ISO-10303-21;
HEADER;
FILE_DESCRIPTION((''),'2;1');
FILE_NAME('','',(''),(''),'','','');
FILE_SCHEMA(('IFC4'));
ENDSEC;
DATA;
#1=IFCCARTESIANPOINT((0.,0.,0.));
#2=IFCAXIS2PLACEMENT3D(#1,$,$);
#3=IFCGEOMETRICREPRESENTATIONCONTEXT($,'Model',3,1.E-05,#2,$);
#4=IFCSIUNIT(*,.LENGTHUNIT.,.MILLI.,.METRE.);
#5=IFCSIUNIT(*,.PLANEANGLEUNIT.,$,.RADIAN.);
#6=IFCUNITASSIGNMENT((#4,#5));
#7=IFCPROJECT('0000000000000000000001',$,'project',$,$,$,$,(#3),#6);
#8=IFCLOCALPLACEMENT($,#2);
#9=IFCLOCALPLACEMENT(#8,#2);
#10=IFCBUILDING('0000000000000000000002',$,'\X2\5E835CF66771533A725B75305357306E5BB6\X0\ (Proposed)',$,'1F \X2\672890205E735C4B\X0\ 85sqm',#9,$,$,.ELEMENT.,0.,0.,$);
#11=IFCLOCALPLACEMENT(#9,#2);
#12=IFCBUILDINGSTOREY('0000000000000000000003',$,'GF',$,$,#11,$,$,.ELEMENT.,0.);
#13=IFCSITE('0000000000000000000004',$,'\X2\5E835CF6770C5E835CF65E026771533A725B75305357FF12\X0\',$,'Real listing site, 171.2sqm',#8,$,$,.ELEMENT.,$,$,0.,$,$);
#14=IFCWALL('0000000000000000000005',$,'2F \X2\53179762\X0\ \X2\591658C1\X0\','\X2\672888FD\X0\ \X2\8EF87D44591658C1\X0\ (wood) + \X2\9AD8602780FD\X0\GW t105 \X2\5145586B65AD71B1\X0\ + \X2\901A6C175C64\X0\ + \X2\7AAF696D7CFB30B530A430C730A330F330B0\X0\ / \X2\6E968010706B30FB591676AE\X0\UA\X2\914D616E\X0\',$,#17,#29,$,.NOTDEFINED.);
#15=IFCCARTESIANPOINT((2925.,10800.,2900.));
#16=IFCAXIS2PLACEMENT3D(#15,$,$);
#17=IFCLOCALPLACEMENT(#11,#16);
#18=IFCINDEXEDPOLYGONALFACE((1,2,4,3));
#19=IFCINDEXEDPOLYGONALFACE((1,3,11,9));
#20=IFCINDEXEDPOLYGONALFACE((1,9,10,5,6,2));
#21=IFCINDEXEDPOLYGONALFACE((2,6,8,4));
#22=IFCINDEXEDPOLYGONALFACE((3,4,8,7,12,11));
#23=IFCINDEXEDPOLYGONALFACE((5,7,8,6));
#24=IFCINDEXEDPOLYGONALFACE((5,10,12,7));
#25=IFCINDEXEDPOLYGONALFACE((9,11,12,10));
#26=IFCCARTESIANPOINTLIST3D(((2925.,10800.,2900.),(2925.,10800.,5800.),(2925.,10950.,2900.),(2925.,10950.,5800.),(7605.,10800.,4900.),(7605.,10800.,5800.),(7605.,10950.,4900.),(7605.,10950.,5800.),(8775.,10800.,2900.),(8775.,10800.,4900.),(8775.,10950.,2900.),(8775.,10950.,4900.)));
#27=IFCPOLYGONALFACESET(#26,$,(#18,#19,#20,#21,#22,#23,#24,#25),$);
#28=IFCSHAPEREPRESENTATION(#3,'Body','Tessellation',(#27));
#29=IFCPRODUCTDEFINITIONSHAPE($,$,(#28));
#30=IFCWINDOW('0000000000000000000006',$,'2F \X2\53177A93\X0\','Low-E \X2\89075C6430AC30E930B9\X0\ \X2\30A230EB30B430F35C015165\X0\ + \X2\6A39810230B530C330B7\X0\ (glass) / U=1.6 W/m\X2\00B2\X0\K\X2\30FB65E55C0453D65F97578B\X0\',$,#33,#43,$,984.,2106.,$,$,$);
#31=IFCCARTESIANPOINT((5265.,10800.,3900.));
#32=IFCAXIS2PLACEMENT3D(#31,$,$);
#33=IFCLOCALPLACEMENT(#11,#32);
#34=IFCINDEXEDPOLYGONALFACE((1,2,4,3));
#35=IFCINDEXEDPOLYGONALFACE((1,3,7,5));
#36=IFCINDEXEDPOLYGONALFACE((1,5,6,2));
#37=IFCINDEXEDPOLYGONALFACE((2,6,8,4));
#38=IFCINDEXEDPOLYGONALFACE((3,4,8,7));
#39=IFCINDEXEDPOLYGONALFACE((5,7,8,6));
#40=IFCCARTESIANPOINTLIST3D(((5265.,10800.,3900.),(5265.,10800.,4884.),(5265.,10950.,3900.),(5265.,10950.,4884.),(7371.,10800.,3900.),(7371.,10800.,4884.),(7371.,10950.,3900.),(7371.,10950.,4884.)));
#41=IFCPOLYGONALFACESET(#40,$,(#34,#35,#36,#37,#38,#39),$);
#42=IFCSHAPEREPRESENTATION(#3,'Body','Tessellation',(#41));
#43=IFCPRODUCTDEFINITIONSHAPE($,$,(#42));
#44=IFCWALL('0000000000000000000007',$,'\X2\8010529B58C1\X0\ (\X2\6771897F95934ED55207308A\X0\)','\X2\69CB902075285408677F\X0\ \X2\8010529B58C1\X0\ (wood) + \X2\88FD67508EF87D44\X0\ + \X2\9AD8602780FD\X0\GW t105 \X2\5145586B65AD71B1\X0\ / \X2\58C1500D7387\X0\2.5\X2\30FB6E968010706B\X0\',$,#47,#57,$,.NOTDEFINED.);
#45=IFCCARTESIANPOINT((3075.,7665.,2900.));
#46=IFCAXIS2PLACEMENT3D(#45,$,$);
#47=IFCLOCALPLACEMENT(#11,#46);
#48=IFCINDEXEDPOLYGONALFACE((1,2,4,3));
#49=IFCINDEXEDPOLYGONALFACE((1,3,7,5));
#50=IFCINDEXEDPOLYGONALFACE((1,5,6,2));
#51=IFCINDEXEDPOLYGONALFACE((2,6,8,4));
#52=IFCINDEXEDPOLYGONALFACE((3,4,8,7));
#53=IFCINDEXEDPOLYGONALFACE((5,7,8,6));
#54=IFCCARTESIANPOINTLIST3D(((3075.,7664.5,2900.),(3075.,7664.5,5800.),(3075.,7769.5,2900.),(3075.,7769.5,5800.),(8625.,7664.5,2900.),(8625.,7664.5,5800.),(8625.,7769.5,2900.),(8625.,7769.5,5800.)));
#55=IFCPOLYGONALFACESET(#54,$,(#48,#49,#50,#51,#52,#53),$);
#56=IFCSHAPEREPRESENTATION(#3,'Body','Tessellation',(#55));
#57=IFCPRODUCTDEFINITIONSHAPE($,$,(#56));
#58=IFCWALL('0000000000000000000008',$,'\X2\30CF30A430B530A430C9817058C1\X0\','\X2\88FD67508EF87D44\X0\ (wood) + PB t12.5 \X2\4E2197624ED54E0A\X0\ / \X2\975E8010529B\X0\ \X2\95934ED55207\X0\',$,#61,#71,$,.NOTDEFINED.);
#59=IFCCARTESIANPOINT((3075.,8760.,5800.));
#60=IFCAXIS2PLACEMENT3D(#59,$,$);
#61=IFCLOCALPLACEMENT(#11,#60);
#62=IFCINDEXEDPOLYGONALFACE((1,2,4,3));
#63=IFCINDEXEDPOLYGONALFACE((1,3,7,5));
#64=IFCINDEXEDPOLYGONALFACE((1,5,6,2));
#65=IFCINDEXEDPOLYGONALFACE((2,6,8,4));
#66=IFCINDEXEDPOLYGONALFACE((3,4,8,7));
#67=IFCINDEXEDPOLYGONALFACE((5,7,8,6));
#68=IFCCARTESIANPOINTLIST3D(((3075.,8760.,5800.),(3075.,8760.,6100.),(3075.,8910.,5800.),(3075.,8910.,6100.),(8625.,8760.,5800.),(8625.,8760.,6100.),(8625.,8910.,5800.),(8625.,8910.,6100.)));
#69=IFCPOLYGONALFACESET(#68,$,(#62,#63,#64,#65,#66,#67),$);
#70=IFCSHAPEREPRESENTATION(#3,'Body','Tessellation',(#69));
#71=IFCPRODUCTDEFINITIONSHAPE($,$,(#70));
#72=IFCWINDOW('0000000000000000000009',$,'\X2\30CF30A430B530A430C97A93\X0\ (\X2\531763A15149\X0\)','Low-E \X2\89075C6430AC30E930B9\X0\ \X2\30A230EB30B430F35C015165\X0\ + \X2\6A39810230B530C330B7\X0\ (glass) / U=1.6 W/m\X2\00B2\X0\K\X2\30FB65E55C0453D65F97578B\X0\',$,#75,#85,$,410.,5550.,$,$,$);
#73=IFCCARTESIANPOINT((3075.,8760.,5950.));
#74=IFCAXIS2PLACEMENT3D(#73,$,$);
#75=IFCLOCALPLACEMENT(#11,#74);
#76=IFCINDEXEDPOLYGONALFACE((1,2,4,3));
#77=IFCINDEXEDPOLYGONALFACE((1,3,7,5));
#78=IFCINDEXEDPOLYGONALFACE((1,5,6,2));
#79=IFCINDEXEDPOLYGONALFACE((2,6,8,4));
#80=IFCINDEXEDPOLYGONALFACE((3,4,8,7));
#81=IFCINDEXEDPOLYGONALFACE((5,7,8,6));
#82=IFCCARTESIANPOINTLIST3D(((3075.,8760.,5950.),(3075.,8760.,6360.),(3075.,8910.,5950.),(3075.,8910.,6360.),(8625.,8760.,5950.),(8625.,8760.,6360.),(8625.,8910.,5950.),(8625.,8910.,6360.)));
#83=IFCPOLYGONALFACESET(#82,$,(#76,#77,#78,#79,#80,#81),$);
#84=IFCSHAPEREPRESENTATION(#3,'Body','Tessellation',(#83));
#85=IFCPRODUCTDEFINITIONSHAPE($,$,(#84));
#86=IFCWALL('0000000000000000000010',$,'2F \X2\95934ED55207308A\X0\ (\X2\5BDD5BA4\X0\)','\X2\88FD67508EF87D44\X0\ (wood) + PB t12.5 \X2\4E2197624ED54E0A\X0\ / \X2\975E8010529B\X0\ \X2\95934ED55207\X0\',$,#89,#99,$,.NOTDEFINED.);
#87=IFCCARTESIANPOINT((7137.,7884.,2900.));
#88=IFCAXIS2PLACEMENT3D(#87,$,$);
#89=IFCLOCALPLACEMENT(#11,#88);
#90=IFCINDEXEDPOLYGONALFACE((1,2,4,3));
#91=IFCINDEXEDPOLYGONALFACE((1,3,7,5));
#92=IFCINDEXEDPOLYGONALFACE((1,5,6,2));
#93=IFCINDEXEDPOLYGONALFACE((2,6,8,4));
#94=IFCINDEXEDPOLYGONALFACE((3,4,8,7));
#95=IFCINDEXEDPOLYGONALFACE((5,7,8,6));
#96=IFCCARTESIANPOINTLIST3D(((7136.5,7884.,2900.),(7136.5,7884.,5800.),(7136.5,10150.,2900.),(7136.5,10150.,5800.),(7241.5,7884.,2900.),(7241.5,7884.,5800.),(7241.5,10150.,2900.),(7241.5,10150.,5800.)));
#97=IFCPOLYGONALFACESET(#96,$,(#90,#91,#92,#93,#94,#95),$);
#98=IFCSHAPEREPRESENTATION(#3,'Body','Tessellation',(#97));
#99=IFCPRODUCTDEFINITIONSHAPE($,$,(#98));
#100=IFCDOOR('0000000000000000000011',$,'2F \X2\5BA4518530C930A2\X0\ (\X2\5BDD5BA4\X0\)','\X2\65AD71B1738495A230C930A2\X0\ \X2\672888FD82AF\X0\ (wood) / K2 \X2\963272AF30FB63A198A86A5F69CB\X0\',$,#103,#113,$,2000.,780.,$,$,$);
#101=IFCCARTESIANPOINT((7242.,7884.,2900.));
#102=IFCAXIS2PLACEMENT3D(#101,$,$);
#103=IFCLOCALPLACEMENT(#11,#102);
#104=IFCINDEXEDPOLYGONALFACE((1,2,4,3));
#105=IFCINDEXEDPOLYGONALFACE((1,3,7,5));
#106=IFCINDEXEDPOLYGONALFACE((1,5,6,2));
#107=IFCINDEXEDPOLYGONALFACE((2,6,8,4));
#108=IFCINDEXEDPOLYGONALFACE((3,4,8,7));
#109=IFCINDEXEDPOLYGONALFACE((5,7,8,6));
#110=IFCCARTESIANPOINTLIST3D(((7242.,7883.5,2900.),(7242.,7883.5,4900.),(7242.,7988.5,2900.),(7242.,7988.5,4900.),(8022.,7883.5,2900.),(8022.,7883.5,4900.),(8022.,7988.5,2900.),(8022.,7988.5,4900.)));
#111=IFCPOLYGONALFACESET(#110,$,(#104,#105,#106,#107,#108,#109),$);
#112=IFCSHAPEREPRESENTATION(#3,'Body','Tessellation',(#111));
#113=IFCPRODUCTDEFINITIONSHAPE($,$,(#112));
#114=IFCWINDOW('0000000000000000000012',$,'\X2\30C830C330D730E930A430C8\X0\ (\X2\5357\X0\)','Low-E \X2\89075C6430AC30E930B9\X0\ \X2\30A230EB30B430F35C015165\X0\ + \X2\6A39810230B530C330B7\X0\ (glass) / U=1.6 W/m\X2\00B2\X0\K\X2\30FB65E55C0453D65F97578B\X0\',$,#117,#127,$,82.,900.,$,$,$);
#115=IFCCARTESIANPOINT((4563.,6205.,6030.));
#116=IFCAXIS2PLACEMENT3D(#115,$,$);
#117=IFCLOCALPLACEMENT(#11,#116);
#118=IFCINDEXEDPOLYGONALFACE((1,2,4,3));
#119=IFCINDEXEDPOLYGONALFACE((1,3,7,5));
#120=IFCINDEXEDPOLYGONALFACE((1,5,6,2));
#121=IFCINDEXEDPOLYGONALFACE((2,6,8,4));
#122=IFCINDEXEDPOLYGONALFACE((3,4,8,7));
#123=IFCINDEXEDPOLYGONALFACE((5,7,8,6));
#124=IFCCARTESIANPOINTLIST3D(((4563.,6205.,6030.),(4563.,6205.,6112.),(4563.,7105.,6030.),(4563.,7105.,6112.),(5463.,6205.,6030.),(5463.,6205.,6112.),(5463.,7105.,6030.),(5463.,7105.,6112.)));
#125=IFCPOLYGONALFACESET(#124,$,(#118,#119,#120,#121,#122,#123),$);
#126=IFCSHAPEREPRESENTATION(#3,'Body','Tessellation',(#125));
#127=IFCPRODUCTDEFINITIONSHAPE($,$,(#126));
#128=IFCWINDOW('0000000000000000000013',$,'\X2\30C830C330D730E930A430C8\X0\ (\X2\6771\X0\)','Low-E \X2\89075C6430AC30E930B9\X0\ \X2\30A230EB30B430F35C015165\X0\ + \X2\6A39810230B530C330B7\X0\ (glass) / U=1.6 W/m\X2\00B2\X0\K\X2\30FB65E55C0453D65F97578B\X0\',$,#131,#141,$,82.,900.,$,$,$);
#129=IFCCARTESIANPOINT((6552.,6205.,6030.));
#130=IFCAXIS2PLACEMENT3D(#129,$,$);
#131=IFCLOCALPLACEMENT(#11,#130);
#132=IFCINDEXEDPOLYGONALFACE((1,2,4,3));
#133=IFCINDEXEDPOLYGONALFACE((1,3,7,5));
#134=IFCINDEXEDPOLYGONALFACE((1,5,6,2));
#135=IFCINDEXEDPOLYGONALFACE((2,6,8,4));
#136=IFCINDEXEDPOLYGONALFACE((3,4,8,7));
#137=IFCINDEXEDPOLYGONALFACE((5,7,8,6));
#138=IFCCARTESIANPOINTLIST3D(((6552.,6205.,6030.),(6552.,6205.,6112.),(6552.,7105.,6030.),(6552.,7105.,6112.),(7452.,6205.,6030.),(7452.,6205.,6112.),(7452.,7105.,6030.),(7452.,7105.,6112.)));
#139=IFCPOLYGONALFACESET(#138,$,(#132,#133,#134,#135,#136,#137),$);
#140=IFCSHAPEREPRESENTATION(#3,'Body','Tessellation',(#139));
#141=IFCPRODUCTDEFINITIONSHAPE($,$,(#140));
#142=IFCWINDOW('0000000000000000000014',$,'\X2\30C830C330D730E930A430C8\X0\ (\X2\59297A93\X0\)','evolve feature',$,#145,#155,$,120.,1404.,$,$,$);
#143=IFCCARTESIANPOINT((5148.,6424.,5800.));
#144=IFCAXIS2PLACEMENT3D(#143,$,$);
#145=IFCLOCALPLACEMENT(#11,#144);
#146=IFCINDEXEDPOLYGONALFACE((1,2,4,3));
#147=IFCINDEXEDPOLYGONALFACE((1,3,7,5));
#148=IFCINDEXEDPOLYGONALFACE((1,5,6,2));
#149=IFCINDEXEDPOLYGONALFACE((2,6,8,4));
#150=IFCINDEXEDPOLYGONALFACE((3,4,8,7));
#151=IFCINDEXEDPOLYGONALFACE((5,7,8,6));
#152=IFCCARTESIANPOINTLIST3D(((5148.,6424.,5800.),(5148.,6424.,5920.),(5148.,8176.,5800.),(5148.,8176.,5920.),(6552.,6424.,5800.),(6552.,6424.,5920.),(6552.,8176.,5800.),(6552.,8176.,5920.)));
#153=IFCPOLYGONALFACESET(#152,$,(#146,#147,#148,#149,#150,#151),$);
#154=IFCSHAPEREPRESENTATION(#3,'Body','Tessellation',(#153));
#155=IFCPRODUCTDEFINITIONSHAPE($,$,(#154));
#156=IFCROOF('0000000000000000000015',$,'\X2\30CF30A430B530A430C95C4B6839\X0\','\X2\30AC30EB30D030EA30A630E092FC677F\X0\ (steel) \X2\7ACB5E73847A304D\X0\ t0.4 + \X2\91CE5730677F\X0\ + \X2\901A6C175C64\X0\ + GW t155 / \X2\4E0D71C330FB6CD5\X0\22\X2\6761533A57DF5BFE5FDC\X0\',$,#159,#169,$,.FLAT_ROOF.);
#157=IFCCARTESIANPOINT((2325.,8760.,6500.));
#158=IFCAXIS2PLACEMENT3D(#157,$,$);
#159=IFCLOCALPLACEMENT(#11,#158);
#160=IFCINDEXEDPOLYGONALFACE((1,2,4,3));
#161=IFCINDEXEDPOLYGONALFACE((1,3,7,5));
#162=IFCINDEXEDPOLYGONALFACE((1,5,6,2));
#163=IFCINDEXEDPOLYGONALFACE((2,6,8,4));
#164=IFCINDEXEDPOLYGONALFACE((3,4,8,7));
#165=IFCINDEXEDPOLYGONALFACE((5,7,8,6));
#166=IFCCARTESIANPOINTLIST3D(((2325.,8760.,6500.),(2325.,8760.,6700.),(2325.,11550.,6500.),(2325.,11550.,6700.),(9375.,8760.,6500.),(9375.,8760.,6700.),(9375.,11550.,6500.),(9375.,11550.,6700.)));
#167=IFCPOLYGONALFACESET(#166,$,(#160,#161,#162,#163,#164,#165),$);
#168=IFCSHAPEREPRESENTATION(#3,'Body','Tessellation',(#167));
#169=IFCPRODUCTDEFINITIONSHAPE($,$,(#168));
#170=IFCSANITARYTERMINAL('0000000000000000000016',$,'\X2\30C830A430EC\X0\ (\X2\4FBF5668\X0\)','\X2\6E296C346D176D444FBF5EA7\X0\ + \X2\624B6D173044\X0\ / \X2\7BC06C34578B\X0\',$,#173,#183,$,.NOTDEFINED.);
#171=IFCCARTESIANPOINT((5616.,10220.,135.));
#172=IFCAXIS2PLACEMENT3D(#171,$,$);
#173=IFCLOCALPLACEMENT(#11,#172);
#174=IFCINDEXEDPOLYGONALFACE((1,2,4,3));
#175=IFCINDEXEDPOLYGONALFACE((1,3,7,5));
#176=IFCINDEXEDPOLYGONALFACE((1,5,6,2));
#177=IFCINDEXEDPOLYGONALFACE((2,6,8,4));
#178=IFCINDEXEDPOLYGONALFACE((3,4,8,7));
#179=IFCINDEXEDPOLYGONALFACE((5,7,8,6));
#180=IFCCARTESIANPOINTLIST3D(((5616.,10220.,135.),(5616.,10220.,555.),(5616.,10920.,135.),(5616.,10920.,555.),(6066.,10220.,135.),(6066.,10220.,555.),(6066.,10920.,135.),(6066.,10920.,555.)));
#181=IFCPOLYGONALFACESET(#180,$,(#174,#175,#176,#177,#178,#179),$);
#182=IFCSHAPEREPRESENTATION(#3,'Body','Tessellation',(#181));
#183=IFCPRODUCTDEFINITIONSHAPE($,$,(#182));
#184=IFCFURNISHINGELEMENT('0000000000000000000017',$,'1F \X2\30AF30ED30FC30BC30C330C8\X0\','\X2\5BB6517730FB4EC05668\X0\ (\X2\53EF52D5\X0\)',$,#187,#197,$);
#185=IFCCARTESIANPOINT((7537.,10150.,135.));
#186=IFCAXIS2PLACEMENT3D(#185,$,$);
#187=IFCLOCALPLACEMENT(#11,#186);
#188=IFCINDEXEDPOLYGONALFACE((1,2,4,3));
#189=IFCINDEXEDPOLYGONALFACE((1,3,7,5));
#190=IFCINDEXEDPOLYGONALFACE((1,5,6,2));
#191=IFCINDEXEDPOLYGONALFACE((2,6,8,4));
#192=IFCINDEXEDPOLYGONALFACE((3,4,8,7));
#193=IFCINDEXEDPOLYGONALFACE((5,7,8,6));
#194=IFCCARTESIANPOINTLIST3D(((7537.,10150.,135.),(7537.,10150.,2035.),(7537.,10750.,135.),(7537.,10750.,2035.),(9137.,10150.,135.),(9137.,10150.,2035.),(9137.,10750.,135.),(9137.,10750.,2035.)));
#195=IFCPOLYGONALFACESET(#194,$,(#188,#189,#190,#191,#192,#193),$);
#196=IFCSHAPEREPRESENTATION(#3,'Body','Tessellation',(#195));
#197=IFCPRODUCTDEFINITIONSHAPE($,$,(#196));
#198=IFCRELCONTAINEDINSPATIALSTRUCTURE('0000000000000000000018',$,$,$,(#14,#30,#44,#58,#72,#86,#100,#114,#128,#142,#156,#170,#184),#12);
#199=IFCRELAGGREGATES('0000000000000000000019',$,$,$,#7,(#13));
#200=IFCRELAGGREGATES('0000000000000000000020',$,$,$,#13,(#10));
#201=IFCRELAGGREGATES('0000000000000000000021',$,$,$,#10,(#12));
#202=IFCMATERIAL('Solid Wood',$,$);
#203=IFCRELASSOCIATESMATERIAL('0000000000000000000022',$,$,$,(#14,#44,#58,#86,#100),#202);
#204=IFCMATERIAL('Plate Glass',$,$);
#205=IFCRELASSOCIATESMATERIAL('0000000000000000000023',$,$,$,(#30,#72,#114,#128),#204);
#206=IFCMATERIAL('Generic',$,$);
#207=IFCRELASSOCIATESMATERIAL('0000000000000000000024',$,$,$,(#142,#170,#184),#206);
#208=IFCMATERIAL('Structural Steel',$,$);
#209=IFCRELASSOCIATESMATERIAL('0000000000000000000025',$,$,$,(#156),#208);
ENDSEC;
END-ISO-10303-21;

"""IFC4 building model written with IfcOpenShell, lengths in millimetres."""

from ifc_helpers import new_model, si_unit, frame, frame_2d, origin, place, context, project, spatial, rectangle, extrude, material, element, fill, save


model = new_model("IFC4")

# Units and contexts
model_context = context("Model", 3, precision=1e-05, world=origin())
ifc_project = project(units=[si_unit("LENGTHUNIT", "METRE", prefix="MILLI"), si_unit("PLANEANGLEUNIT", "RADIAN")], contexts=[model_context])

# Site, building, storey
site_placement = place(None, origin())
site = spatial("IfcSite", under=ifc_project, at=site_placement, Name="広島県広島市東区牛田南２", ObjectType="Real listing site, 171.2sqm", CompositionType="ELEMENT", RefElevation=0.0)
building_placement = place(site_placement, origin())
building = spatial("IfcBuilding", under=site, at=building_placement, Name="広島東区牛田南の家 (Proposed)", ObjectType="1F 木造平屋 85sqm", CompositionType="ELEMENT", ElevationOfRefHeight=0.0, ElevationOfTerrain=0.0)
storey_placement = place(building_placement, origin())
storey = spatial("IfcBuildingStorey", under=building, at=storey_placement, Name="GF", CompositionType="ELEMENT", Elevation=0.0)

# Wall, opening, window
ifc_material_1 = material(Name="Solid Wood")
wall_1_placement = place(storey_placement, frame((2925.0, 10800.0, 2900.0)))
wall_1 = element("IfcWall", 1, at=wall_1_placement, inside=storey, material=ifc_material_1, Name="2F 北面 外壁", Description="木製 軸組外壁 (wood) + 高性能GW t105 充填断熱 + 通気層 + 窯業系サイディング / 準耐火・外皮UA配慮", PredefinedType="NOTDEFINED", context=model_context, shape_type="SweptSolid", body=[
    extrude(rectangle(XDim=5850.0, YDim=150.0, at=frame_2d((2925.0, 75.0))), frame((2925.0, 10800.0, 2900.0)), (0.0, 0.0, 1.0), 2900.0),
])
opening_1_placement = place(storey_placement, frame((5265.0, 10800.0, 3900.0)))
opening_1 = element("IfcOpeningElement", 2, at=opening_1_placement, cuts=wall_1, PredefinedType="NOTDEFINED", context=model_context, shape_type="SweptSolid", body=[
    extrude(rectangle(XDim=2106.0, YDim=150.0, at=frame_2d((1053.0, 75.0))), frame((5265.0, 10800.0, 3900.0)), (0.0, 0.0, 1.0), 984.0),
])
ifc_material_2 = material(Name="Plate Glass")
window_1_placement = place(storey_placement, frame((5265.0, 10800.0, 3900.0)))
window_1 = element("IfcWindow", 3, at=window_1_placement, inside=storey, material=ifc_material_2, Name="2F 北窓", Description="Low-E 複層ガラス アルゴン封入 + 樹脂サッシ (glass) / U=1.6 W/m²K・日射取得型", OverallHeight=984.0, OverallWidth=2106.0, context=model_context, shape_type="SweptSolid", body=[
    extrude(rectangle(XDim=2106.0, YDim=150.0, at=frame_2d((1053.0, 75.0))), frame((5265.0, 10800.0, 3900.0)), (0.0, 0.0, 1.0), 984.0),
])
fill(opening_1, window_1)

# Wall
wall_2_placement = place(storey_placement, frame((3075.0, 7665.0, 2900.0)))
element("IfcWall", 4, at=wall_2_placement, inside=storey, material=ifc_material_1, Name="耐力壁 (東西間仕切り)", Description="構造用合板 耐力壁 (wood) + 製材軸組 + 高性能GW t105 充填断熱 / 壁倍率2.5・準耐火", PredefinedType="NOTDEFINED", context=model_context, shape_type="SweptSolid", body=[
    extrude(rectangle(XDim=5550.0, YDim=105.0, at=frame_2d((2775.0, 52.0))), frame((3075.0, 7665.0, 2900.0)), (0.0, 0.0, 1.0), 2900.0),
])

# Wall, opening, window
wall_3_placement = place(storey_placement, frame((3075.0, 8760.0, 5800.0)))
wall_3 = element("IfcWall", 5, at=wall_3_placement, inside=storey, material=ifc_material_1, Name="ハイサイド腰壁", Description="製材軸組 (wood) + PB t12.5 両面仕上 / 非耐力 間仕切", PredefinedType="NOTDEFINED", context=model_context, shape_type="SweptSolid", body=[
    extrude(rectangle(XDim=5550.0, YDim=150.0, at=frame_2d((2775.0, 75.0))), frame((3075.0, 8760.0, 5800.0)), (0.0, 0.0, 1.0), 700.0),
])
opening_2_placement = place(storey_placement, frame((3075.0, 8760.0, 5950.0)))
opening_2 = element("IfcOpeningElement", 6, at=opening_2_placement, cuts=wall_3, PredefinedType="NOTDEFINED", context=model_context, shape_type="SweptSolid", body=[
    extrude(rectangle(XDim=5550.0, YDim=150.0, at=frame_2d((2775.0, 75.0))), frame((3075.0, 8760.0, 5950.0)), (0.0, 0.0, 1.0), 410.0),
])
window_2_placement = place(storey_placement, frame((3075.0, 8760.0, 5950.0)))
window_2 = element("IfcWindow", 7, at=window_2_placement, inside=storey, material=ifc_material_2, Name="ハイサイド窓 (北採光)", Description="Low-E 複層ガラス アルゴン封入 + 樹脂サッシ (glass) / U=1.6 W/m²K・日射取得型", OverallHeight=410.0, OverallWidth=5550.0, context=model_context, shape_type="SweptSolid", body=[
    extrude(rectangle(XDim=5550.0, YDim=150.0, at=frame_2d((2775.0, 75.0))), frame((3075.0, 8760.0, 5950.0)), (0.0, 0.0, 1.0), 410.0),
])
fill(opening_2, window_2)

# Wall
wall_4_placement = place(storey_placement, frame((7137.0, 7884.0, 2900.0)))
element("IfcWall", 8, at=wall_4_placement, inside=storey, material=ifc_material_1, Name="2F 間仕切り (寝室)", Description="製材軸組 (wood) + PB t12.5 両面仕上 / 非耐力 間仕切", PredefinedType="NOTDEFINED", context=model_context, shape_type="SweptSolid", body=[
    extrude(rectangle(XDim=105.0, YDim=2266.0, at=frame_2d((52.0, 1133.0))), frame((7137.0, 7884.0, 2900.0)), (0.0, 0.0, 1.0), 2900.0),
])

# Door
door_placement = place(storey_placement, frame((7242.0, 7884.0, 2900.0)))
element("IfcDoor", 9, at=door_placement, inside=storey, material=ifc_material_1, Name="2F 室内ドア (寝室)", Description="断熱玄関ドア 木製芯 (wood) / K2 防犯・採風機構", OverallHeight=2000.0, OverallWidth=780.0, context=model_context, shape_type="SweptSolid", body=[
    extrude(rectangle(XDim=780.0, YDim=105.0, at=frame_2d((390.0, 52.0))), frame((7242.0, 7884.0, 2900.0)), (0.0, 0.0, 1.0), 2000.0),
])

# Windows
window_3_placement = place(storey_placement, frame((4563.0, 6205.0, 6030.0)))
element("IfcWindow", 10, at=window_3_placement, inside=storey, material=ifc_material_2, Name="トップライト (南)", Description="Low-E 複層ガラス アルゴン封入 + 樹脂サッシ (glass) / U=1.6 W/m²K・日射取得型", OverallHeight=82.0, OverallWidth=900.0, context=model_context, shape_type="SweptSolid", body=[
    extrude(rectangle(XDim=900.0, YDim=900.0, at=frame_2d((450.0, 450.0))), frame((4563.0, 6205.0, 6030.0)), (0.0, 0.0, 1.0), 82.0),
])
window_4_placement = place(storey_placement, frame((6552.0, 6205.0, 6030.0)))
element("IfcWindow", 11, at=window_4_placement, inside=storey, material=ifc_material_2, Name="トップライト (東)", Description="Low-E 複層ガラス アルゴン封入 + 樹脂サッシ (glass) / U=1.6 W/m²K・日射取得型", OverallHeight=82.0, OverallWidth=900.0, context=model_context, shape_type="SweptSolid", body=[
    extrude(rectangle(XDim=900.0, YDim=900.0, at=frame_2d((450.0, 450.0))), frame((6552.0, 6205.0, 6030.0)), (0.0, 0.0, 1.0), 82.0),
])
ifc_material_3 = material(Name="Generic")
window_5_placement = place(storey_placement, frame((5148.0, 6424.0, 5800.0)))
element("IfcWindow", 12, at=window_5_placement, inside=storey, material=ifc_material_3, Name="トップライト (天窓)", Description="evolve feature", OverallHeight=120.0, OverallWidth=1404.0, context=model_context, shape_type="SweptSolid", body=[
    extrude(rectangle(XDim=1404.0, YDim=1752.0, at=frame_2d((702.0, 876.0))), frame((5148.0, 6424.0, 5800.0)), (0.0, 0.0, 1.0), 120.0),
])

# Roof
ifc_material_4 = material(Name="Structural Steel")
roof_placement = place(storey_placement, frame((2325.0, 8760.0, 6500.0)))
element("IfcRoof", 13, at=roof_placement, inside=storey, material=ifc_material_4, Name="ハイサイド屋根", Description="ガルバリウム鋼板 (steel) 立平葺き t0.4 + 野地板 + 通気層 + GW t155 / 不燃・法22条区域対応", PredefinedType="FLAT_ROOF", context=model_context, shape_type="SweptSolid", body=[
    extrude(rectangle(XDim=7050.0, YDim=2790.0, at=frame_2d((3525.0, 1395.0))), frame((2325.0, 8760.0, 6500.0)), (0.0, 0.0, 1.0), 200.0),
])

# Sanitary terminal
sanitary_terminal_placement = place(storey_placement, frame((5616.0, 10220.0, 135.0)))
element("IfcSanitaryTerminal", 14, at=sanitary_terminal_placement, inside=storey, material=ifc_material_3, Name="トイレ (便器)", Description="温水洗浄便座 + 手洗い / 節水型", PredefinedType="NOTDEFINED", context=model_context, shape_type="SweptSolid", body=[
    extrude(rectangle(XDim=450.0, YDim=700.0, at=frame_2d((225.0, 350.0))), frame((5616.0, 10220.0, 135.0)), (0.0, 0.0, 1.0), 420.0),
])

# Furnishing element
furnishing_1_placement = place(storey_placement, frame((7537.0, 10150.0, 135.0)))
element("IfcFurnishingElement", 15, at=furnishing_1_placement, inside=storey, material=ifc_material_3, Name="1F クローゼット", Description="家具・什器 (可動)", context=model_context, shape_type="SweptSolid", body=[
    extrude(rectangle(XDim=1600.0, YDim=600.0, at=frame_2d((800.0, 300.0))), frame((7537.0, 10150.0, 135.0)), (0.0, 0.0, 1.0), 1900.0),
])

save(model, "model.ifc")
